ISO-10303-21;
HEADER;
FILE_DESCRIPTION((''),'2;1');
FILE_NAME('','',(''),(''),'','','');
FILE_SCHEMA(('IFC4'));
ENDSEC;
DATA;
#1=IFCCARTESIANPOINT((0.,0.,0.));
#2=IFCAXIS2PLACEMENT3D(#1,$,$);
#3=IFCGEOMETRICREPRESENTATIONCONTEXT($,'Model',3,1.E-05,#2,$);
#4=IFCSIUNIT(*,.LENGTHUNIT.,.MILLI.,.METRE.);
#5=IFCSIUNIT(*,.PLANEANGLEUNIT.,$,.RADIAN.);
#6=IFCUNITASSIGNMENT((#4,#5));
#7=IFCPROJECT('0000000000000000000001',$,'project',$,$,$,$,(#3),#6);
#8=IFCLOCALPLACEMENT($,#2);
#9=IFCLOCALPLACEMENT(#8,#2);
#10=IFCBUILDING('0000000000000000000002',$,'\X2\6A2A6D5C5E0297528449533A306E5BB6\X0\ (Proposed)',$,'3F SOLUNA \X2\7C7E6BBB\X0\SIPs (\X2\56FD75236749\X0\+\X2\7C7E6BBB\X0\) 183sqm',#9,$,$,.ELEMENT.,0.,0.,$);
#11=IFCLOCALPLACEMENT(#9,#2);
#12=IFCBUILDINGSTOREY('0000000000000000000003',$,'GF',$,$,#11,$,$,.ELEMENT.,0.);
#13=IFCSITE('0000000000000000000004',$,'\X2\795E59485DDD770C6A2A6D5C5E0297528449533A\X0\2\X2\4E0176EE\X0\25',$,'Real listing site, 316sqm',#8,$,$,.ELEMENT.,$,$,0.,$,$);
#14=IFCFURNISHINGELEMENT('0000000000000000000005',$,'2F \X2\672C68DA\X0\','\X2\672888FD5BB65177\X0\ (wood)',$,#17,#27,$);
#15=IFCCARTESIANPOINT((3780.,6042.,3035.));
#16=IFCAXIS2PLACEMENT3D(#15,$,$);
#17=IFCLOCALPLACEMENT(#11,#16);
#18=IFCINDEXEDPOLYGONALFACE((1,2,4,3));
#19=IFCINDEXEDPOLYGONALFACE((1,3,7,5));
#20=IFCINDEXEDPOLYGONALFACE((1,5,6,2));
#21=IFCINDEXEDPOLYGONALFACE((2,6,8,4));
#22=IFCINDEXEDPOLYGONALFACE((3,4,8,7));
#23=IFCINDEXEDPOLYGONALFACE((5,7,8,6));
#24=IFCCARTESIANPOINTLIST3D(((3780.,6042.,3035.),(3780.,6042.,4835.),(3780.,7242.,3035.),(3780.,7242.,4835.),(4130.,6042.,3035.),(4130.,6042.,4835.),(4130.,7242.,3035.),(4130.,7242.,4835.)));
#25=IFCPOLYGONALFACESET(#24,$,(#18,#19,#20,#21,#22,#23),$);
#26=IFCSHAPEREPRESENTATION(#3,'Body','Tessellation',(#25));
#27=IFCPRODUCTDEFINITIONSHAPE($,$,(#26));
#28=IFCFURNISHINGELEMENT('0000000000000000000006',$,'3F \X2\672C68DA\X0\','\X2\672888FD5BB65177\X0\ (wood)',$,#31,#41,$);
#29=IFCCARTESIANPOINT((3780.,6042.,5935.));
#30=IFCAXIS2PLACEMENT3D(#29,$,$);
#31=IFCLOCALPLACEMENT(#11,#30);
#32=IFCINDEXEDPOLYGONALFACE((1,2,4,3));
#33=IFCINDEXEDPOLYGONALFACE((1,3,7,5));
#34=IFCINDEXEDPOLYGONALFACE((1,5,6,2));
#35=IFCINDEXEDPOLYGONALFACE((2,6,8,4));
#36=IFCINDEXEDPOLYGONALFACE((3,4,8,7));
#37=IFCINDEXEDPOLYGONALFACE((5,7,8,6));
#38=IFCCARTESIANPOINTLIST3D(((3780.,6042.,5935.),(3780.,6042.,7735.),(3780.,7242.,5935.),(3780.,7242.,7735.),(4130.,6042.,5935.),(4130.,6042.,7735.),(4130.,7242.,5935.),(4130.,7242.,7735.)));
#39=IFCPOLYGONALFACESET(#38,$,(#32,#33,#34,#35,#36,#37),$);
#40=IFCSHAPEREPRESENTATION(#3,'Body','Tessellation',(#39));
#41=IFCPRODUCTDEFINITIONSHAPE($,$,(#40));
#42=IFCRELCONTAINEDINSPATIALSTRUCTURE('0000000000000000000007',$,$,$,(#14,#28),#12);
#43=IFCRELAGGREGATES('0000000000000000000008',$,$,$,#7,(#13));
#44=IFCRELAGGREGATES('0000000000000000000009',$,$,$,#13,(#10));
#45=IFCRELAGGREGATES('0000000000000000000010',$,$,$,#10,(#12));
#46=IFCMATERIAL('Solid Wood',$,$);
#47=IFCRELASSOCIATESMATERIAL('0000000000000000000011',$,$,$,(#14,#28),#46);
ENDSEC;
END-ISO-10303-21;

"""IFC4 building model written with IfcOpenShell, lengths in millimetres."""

from ifc_helpers import new_model, si_unit, frame, frame_2d, origin, place, context, project, spatial, rectangle, extrude, material, element, save


model = new_model("IFC4")

# Units and contexts
model_context = context("Model", 3, precision=1e-05, world=origin())
ifc_project = project(units=[si_unit("LENGTHUNIT", "METRE", prefix="MILLI"), si_unit("PLANEANGLEUNIT", "RADIAN")], contexts=[model_context])

# Site, building, storey
site_placement = place(None, origin())
site = spatial("IfcSite", under=ifc_project, at=site_placement, Name="神奈川県横浜市青葉区2丁目25", ObjectType="Real listing site, 316sqm", CompositionType="ELEMENT", RefElevation=0.0)
building_placement = place(site_placement, origin())
building = spatial("IfcBuilding", under=site, at=building_placement, Name="横浜市青葉区の家 (Proposed)", ObjectType="3F SOLUNA 籾殻SIPs (国産杉+籾殻) 183sqm", CompositionType="ELEMENT", ElevationOfRefHeight=0.0, ElevationOfTerrain=0.0)
storey_placement = place(building_placement, origin())
storey = spatial("IfcBuildingStorey", under=building, at=storey_placement, Name="GF", CompositionType="ELEMENT", Elevation=0.0)

# Shared definitions
ifc_material_1 = material(Name="Solid Wood")

# Furnishing elements
furnishing_1_placement = place(storey_placement, frame((3780.0, 6042.0, 3035.0)))
element("IfcFurnishingElement", 1, at=furnishing_1_placement, inside=storey, material=ifc_material_1, Name="2F 本棚", Description="木製家具 (wood)", context=model_context, shape_type="SweptSolid", body=[
    extrude(rectangle(XDim=350.0, YDim=1200.0, at=frame_2d((175.0, 600.0))), frame((3780.0, 6042.0, 3035.0)), (0.0, 0.0, 1.0), 1800.0),
])
furnishing_2_placement = place(storey_placement, frame((3780.0, 6042.0, 5935.0)))
element("IfcFurnishingElement", 2, at=furnishing_2_placement, inside=storey, material=ifc_material_1, Name="3F 本棚", Description="木製家具 (wood)", context=model_context, shape_type="SweptSolid", body=[
    extrude(rectangle(XDim=350.0, YDim=1200.0, at=frame_2d((175.0, 600.0))), frame((3780.0, 6042.0, 5935.0)), (0.0, 0.0, 1.0), 1800.0),
])

save(model, "model.ifc")
